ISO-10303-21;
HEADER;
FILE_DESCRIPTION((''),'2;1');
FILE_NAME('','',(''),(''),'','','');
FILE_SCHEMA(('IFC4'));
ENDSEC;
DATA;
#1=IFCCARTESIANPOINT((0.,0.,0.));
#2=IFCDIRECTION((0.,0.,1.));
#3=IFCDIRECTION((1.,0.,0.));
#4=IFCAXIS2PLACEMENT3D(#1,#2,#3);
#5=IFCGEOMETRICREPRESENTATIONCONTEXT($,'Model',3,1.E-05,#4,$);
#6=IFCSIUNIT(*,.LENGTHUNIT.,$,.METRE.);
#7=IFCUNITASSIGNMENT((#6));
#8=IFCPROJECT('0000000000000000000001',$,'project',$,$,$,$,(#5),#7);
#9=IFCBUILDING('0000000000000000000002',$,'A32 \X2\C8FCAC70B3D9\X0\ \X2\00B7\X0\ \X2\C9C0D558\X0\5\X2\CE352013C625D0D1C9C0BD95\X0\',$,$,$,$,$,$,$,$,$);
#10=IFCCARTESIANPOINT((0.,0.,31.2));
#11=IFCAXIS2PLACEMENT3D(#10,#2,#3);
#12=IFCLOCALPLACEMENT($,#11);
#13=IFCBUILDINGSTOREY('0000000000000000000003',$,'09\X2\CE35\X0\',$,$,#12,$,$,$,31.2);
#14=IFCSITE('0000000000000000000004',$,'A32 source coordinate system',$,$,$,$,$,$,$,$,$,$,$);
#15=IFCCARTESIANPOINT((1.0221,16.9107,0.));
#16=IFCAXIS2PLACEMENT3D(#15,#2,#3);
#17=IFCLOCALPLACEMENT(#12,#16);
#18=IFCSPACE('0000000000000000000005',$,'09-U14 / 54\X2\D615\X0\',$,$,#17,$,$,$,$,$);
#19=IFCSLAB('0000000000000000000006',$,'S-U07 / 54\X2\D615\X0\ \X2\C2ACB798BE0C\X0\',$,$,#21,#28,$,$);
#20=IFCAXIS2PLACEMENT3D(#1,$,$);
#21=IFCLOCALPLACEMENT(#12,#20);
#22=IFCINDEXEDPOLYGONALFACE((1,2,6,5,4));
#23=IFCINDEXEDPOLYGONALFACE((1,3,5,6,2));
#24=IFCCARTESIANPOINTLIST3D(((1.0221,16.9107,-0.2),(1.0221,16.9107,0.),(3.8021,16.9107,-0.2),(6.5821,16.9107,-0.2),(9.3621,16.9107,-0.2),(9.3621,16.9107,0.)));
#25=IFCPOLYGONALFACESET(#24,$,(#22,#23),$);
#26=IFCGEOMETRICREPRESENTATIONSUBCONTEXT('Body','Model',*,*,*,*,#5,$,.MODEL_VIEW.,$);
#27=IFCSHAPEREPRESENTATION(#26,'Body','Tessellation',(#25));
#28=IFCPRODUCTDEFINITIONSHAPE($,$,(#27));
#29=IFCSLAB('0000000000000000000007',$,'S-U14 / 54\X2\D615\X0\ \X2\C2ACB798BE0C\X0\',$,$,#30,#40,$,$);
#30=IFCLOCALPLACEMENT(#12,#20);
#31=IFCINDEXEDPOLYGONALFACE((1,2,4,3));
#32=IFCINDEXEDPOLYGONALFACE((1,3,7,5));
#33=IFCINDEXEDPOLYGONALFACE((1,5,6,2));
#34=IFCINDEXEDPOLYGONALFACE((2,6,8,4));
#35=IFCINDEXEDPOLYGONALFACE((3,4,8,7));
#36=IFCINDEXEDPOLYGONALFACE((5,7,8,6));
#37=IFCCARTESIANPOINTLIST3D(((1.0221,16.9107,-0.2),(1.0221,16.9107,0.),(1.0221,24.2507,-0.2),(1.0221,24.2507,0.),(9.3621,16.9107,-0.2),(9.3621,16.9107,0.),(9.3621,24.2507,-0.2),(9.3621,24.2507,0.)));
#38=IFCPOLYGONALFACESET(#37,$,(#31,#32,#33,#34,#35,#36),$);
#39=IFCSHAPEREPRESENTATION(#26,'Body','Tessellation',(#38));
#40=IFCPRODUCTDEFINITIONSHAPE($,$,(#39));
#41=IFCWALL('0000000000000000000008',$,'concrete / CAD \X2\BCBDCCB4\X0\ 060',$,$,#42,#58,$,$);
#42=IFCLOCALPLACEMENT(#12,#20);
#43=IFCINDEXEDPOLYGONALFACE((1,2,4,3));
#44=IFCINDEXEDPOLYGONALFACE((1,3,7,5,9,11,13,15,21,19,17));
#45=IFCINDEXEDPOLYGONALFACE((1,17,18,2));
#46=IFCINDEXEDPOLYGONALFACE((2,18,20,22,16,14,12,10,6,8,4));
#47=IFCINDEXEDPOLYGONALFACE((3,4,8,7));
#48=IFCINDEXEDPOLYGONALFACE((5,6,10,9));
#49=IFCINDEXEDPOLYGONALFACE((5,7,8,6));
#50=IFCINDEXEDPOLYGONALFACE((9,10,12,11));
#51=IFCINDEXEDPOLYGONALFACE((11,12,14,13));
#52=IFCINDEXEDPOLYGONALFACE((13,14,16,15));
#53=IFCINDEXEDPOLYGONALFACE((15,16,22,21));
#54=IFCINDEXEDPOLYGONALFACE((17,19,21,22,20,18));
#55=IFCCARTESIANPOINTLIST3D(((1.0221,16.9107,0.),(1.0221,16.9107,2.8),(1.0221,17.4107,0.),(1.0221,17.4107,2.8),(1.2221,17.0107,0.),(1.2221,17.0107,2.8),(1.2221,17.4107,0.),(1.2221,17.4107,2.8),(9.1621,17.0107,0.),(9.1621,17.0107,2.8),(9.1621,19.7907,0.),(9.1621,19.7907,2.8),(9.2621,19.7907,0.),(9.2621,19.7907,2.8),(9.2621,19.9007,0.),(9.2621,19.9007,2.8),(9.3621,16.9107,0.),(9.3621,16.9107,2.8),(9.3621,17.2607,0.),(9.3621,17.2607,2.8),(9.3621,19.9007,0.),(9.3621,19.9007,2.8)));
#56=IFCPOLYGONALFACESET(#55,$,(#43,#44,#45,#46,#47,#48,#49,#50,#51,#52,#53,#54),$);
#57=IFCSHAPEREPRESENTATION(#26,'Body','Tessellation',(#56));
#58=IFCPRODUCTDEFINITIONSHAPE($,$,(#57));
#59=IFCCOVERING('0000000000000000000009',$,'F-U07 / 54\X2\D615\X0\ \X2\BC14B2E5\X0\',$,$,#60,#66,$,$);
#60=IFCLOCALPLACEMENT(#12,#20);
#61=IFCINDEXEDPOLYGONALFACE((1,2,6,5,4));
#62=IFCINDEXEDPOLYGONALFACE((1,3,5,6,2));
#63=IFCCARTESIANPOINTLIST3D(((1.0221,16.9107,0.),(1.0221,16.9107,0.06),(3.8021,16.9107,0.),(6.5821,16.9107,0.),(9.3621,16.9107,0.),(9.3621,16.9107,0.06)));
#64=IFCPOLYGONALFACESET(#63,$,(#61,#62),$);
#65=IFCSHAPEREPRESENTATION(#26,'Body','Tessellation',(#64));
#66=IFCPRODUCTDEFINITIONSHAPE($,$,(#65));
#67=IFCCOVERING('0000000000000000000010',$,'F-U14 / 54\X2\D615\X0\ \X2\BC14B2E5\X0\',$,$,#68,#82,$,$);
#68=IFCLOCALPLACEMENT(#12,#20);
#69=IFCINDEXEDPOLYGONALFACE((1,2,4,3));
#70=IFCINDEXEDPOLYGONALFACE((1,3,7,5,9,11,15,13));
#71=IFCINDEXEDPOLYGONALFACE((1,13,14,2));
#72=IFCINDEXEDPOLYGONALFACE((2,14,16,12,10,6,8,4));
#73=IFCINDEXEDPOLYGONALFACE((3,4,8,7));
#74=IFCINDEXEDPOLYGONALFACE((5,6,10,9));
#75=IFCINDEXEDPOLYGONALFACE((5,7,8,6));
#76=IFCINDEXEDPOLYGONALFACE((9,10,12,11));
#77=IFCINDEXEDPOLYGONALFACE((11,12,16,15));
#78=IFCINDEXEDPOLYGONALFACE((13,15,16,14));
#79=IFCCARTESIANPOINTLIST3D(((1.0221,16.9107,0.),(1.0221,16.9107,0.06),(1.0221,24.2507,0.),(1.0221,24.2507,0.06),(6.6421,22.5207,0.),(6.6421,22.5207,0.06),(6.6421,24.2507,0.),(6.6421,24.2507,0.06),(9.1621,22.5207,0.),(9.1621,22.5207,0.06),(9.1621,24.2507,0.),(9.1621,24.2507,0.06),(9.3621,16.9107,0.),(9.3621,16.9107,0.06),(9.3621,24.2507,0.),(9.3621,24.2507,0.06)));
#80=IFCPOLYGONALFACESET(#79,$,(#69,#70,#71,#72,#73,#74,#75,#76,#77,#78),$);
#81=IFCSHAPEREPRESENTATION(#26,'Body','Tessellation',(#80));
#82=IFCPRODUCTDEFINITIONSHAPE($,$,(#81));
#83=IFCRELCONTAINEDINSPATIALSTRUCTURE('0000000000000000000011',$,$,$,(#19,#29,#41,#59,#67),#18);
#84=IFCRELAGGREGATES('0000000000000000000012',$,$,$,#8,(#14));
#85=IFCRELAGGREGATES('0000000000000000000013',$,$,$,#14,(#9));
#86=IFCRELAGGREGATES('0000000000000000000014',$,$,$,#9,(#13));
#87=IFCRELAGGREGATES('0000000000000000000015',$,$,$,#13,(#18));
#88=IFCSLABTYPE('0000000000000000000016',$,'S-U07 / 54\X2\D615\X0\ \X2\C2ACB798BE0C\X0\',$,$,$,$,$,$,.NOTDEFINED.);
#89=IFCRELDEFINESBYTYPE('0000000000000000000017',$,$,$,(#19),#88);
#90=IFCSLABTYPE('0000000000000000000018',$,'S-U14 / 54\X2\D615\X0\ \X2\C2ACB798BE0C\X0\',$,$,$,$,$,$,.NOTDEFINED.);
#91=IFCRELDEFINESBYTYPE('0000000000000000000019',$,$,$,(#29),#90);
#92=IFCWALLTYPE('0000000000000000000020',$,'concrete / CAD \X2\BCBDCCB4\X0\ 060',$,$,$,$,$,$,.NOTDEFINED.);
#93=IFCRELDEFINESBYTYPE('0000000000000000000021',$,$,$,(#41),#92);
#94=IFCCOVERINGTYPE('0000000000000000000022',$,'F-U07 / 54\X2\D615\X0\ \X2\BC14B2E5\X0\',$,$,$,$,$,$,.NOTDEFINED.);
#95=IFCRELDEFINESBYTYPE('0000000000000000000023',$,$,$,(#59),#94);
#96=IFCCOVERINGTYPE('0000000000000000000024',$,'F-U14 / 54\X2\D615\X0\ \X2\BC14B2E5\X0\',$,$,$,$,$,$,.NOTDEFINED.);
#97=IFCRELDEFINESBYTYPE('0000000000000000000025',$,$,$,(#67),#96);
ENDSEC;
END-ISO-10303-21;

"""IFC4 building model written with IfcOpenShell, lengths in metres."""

from ifc_helpers import new_model, si_unit, frame, origin, origin_with_axes, place, context, subcontext, project, spatial, polyline, outline, extrude, source, transform, mapped, type_object, type_shapes, element, save


model = new_model("IFC4")

# Units and contexts
model_context = context("Model", 3, precision=1e-05, world=origin_with_axes())
body_context = subcontext(model_context, "Body", "Model", "MODEL_VIEW")
ifc_project = project(units=[si_unit("LENGTHUNIT", "METRE")], contexts=[model_context])

# Site, building, storey, space
storey_placement = place(None, frame((0.0, 0.0, 31.2), z_axis=(0.0, 0.0, 1.0), x_axis=(1.0, 0.0, 0.0)))
space_1_placement = place(storey_placement, frame((1.0221, 16.9107, 0.0), z_axis=(0.0, 0.0, 1.0), x_axis=(1.0, 0.0, 0.0)))
site = spatial("IfcSite", under=ifc_project, Name="A32 source coordinate system")
building = spatial("IfcBuilding", under=site, Name="A32 주거동 · 지하5층–옥탑지붕")
storey = spatial("IfcBuildingStorey", under=building, at=storey_placement, Name="09층", Elevation=31.2)
space_1 = spatial("IfcSpace", under=storey, at=space_1_placement, Name="09-U14 / 54형")

# Slabs
slab_type_1 = type_object("IfcSlabType", Name="S-U07 / 54형 슬래브", PredefinedType="NOTDEFINED")
shared_shape_1 = source(origin(), body_context, "Body", "SweptSolid", [
    extrude(outline(polyline([(0.0, 0.0), (0.0, 0.0), (8.34, 0.0), (8.34, 0.0), (0.0, 0.0)])), frame((0.0, 0.0, -0.2)), (0.0, 0.0, 1.0), 0.2),
])
type_shapes(slab_type_1, [shared_shape_1])
slab_1_placement = place(space_1_placement, origin_with_axes())
element("IfcSlab", 1, at=slab_1_placement, inside=space_1, type_object=slab_type_1, Name="S-U07 / 54형 슬래브", context=body_context, shape_type="MappedRepresentation", body=[
    mapped(shared_shape_1, transform((0.0, 0.0, 0.0), scale=1.0)),
])
slab_type_2 = type_object("IfcSlabType", Name="S-U14 / 54형 슬래브", PredefinedType="NOTDEFINED")
shared_shape_2 = source(origin(), body_context, "Body", "SweptSolid", [
    extrude(outline(polyline([(0.0, 0.0), (0.0, 7.34), (8.34, 7.34), (8.34, 0.0), (0.0, 0.0)])), frame((0.0, 0.0, -0.2)), (0.0, 0.0, 1.0), 0.2),
])
type_shapes(slab_type_2, [shared_shape_2])
slab_2_placement = place(space_1_placement, origin_with_axes())
element("IfcSlab", 2, at=slab_2_placement, inside=space_1, type_object=slab_type_2, Name="S-U14 / 54형 슬래브", context=body_context, shape_type="MappedRepresentation", body=[
    mapped(shared_shape_2, transform((0.0, 0.0, 0.0), scale=1.0)),
])

# Wall
wall_type_1 = type_object("IfcWallType", Name="concrete / CAD 벽체 060", PredefinedType="NOTDEFINED")
shared_shape_3 = source(origin(), body_context, "Body", "SweptSolid", [
    extrude(outline(polyline([(0.2, 0.5), (0.2, 0.1), (8.14, 0.1), (8.14, 2.88), (8.24, 2.88), (8.24, 2.99), (8.34, 2.99), (8.34, 0.35), (8.34, 0.35), (8.34, 0.0), (0.0, 0.0), (0.0, 0.5), (0.2, 0.5)])), origin(), (0.0, 0.0, 1.0), 2.8),
])
type_shapes(wall_type_1, [shared_shape_3])
wall_1_placement = place(space_1_placement, origin_with_axes())
element("IfcWall", 3, at=wall_1_placement, inside=space_1, type_object=wall_type_1, Name="concrete / CAD 벽체 060", context=body_context, shape_type="MappedRepresentation", body=[
    mapped(shared_shape_3, transform((0.0, 0.0, 0.0), scale=1.0)),
])

# Coverings
covering_type_1 = type_object("IfcCoveringType", Name="F-U07 / 54형 바닥", PredefinedType="NOTDEFINED")
shared_shape_4 = source(origin(), body_context, "Body", "SweptSolid", [
    extrude(outline(polyline([(0.0, 0.0), (0.0, 0.0), (8.34, 0.0), (8.34, 0.0), (0.0, 0.0)])), origin(), (0.0, 0.0, 1.0), 0.06),
])
type_shapes(covering_type_1, [shared_shape_4])
covering_1_placement = place(space_1_placement, origin_with_axes())
element("IfcCovering", 4, at=covering_1_placement, inside=space_1, type_object=covering_type_1, Name="F-U07 / 54형 바닥", context=body_context, shape_type="MappedRepresentation", body=[
    mapped(shared_shape_4, transform((0.0, 0.0, 0.0), scale=1.0)),
])
covering_type_2 = type_object("IfcCoveringType", Name="F-U14 / 54형 바닥", PredefinedType="NOTDEFINED")
shared_shape_5 = source(origin(), body_context, "Body", "SweptSolid", [
    extrude(outline(polyline([(8.14, 7.34), (8.34, 7.34), (8.34, 0.0), (0.0, 0.0), (0.0, 7.34), (5.62, 7.34), (5.62, 5.61), (8.14, 5.61), (8.14, 7.34)])), origin(), (0.0, 0.0, 1.0), 0.06),
])
type_shapes(covering_type_2, [shared_shape_5])
covering_2_placement = place(space_1_placement, origin_with_axes())
element("IfcCovering", 5, at=covering_2_placement, inside=space_1, type_object=covering_type_2, Name="F-U14 / 54형 바닥", context=body_context, shape_type="MappedRepresentation", body=[
    mapped(shared_shape_5, transform((0.0, 0.0, 0.0), scale=1.0)),
])

save(model, "model.ifc")
